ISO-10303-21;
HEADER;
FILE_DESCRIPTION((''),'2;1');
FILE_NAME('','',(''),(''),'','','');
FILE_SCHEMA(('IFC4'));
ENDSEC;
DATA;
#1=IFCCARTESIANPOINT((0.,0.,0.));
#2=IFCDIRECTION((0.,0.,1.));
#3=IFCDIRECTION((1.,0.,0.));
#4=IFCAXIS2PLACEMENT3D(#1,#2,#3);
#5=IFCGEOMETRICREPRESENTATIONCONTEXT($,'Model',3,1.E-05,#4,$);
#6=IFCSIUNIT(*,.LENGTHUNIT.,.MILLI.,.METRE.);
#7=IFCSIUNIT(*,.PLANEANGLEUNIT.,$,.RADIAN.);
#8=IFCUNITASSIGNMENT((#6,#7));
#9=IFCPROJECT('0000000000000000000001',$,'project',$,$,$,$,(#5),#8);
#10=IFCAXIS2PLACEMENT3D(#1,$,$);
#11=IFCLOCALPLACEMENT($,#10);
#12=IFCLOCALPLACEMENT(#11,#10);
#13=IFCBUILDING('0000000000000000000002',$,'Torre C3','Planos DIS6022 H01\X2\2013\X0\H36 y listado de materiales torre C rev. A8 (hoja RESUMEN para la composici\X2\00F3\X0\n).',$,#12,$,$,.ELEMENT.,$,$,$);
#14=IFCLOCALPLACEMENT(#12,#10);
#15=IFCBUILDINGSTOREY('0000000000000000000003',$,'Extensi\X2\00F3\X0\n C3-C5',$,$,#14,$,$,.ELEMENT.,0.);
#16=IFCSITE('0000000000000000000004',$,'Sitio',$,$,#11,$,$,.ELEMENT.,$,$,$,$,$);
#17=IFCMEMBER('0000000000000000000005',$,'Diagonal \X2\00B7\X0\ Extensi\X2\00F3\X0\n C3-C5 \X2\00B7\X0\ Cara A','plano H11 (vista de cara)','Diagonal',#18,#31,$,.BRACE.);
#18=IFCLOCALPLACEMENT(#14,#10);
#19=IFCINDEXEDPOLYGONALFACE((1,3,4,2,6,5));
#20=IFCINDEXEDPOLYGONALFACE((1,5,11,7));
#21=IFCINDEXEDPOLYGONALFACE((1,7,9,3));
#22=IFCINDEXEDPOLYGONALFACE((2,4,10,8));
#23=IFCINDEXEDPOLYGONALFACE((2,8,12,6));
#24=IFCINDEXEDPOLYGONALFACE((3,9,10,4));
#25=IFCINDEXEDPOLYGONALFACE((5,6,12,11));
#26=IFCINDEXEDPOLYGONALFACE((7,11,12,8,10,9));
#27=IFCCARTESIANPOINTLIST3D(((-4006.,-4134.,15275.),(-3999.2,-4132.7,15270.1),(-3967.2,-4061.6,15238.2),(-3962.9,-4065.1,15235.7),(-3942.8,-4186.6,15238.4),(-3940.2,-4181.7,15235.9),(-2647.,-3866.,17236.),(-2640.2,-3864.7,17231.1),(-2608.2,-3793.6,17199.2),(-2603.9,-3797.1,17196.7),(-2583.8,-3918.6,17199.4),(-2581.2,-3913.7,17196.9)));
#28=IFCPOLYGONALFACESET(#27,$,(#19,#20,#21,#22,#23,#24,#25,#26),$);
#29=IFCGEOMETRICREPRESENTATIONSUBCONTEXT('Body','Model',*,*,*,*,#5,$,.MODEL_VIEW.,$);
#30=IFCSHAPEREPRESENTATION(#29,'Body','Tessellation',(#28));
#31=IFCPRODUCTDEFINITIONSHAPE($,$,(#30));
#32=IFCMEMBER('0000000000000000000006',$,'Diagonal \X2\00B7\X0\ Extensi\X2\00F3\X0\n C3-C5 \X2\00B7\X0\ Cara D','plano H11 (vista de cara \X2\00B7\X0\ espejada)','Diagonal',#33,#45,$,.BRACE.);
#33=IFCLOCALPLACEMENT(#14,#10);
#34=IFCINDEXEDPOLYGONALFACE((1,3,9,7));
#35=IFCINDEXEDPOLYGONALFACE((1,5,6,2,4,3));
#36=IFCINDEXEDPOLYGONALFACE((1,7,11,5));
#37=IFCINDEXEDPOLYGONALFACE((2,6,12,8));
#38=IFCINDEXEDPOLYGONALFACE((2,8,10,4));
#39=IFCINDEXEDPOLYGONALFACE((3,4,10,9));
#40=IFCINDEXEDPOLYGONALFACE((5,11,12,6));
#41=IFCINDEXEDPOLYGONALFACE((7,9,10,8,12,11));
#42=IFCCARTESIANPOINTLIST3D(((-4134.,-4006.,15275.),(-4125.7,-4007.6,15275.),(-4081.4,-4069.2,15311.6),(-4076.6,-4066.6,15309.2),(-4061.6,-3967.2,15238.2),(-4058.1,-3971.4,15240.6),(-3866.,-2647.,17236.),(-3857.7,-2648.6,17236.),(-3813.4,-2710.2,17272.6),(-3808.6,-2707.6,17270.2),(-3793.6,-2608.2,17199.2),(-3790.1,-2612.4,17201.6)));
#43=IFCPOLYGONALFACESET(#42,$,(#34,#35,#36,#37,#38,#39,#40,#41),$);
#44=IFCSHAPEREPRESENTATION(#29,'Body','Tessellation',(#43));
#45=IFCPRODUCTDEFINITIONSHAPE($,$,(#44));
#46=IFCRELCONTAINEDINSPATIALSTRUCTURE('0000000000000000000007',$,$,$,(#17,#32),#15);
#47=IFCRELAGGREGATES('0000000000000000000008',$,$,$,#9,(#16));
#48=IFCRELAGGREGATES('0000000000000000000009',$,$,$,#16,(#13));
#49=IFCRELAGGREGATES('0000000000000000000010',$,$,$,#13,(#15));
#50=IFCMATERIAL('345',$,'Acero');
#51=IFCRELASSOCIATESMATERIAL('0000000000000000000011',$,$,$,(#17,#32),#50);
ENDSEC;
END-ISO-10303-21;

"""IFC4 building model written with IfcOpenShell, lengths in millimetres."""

from ifc_helpers import new_model, si_unit, frame, frame_2d, origin, origin_with_axes, place, context, subcontext, project, spatial, l_section, extrude, material, element, save


model = new_model("IFC4")

# Units and contexts
model_context = context("Model", 3, precision=1e-05, world=origin_with_axes())
body_context = subcontext(model_context, "Body", "Model", "MODEL_VIEW")
ifc_project = project(units=[si_unit("LENGTHUNIT", "METRE", prefix="MILLI"), si_unit("PLANEANGLEUNIT", "RADIAN")], contexts=[model_context])

# Site, building, storey
site_placement = place(None, origin())
site = spatial("IfcSite", under=ifc_project, at=site_placement, Name="Sitio", CompositionType="ELEMENT")
building_placement = place(site_placement, origin())
building = spatial("IfcBuilding", under=site, at=building_placement, Name="Torre C3", Description="Planos DIS6022 H01–H36 y listado de materiales torre C rev. A8 (hoja RESUMEN para la composición).", CompositionType="ELEMENT")
storey_placement = place(building_placement, origin())
storey = spatial("IfcBuildingStorey", under=building, at=storey_placement, Name="Extensión C3-C5", CompositionType="ELEMENT", Elevation=0.0)

# Members
ifc_material_1 = material(Name="345", Category="Acero")
for number, where, z_axis, x_axis, name, description in (
    (1, (-2647.0, -3866.0, 17236.0), (-0.566042, -0.111626, -0.816784), (0.431647, 0.803983, -0.409013), "Diagonal · Extensión C3-C5 · Cara A", "plano H11 (vista de cara)"),
    (2, (-3866.0, -2647.0, 17236.0), (-0.111626, -0.566042, -0.816784), (0.803983, 0.431647, -0.409013), "Diagonal · Extensión C3-C5 · Cara D", "plano H11 (vista de cara · espejada)"),
):
    element("IfcMember", number, at=place(storey_placement, frame(where, z_axis=z_axis, x_axis=x_axis)), inside=storey, material=ifc_material_1, Name=name, Description=description, ObjectType="Diagonal", PredefinedType="BRACE", context=body_context, shape_type="SweptSolid", body=[
        extrude(l_section(Depth=90.0, Width=90.0, Thickness=6.0, at=frame_2d((45.0, 45.0))), None, (0.0, 0.0, 1.0), 2400.9),
    ])

save(model, "model.ifc")
